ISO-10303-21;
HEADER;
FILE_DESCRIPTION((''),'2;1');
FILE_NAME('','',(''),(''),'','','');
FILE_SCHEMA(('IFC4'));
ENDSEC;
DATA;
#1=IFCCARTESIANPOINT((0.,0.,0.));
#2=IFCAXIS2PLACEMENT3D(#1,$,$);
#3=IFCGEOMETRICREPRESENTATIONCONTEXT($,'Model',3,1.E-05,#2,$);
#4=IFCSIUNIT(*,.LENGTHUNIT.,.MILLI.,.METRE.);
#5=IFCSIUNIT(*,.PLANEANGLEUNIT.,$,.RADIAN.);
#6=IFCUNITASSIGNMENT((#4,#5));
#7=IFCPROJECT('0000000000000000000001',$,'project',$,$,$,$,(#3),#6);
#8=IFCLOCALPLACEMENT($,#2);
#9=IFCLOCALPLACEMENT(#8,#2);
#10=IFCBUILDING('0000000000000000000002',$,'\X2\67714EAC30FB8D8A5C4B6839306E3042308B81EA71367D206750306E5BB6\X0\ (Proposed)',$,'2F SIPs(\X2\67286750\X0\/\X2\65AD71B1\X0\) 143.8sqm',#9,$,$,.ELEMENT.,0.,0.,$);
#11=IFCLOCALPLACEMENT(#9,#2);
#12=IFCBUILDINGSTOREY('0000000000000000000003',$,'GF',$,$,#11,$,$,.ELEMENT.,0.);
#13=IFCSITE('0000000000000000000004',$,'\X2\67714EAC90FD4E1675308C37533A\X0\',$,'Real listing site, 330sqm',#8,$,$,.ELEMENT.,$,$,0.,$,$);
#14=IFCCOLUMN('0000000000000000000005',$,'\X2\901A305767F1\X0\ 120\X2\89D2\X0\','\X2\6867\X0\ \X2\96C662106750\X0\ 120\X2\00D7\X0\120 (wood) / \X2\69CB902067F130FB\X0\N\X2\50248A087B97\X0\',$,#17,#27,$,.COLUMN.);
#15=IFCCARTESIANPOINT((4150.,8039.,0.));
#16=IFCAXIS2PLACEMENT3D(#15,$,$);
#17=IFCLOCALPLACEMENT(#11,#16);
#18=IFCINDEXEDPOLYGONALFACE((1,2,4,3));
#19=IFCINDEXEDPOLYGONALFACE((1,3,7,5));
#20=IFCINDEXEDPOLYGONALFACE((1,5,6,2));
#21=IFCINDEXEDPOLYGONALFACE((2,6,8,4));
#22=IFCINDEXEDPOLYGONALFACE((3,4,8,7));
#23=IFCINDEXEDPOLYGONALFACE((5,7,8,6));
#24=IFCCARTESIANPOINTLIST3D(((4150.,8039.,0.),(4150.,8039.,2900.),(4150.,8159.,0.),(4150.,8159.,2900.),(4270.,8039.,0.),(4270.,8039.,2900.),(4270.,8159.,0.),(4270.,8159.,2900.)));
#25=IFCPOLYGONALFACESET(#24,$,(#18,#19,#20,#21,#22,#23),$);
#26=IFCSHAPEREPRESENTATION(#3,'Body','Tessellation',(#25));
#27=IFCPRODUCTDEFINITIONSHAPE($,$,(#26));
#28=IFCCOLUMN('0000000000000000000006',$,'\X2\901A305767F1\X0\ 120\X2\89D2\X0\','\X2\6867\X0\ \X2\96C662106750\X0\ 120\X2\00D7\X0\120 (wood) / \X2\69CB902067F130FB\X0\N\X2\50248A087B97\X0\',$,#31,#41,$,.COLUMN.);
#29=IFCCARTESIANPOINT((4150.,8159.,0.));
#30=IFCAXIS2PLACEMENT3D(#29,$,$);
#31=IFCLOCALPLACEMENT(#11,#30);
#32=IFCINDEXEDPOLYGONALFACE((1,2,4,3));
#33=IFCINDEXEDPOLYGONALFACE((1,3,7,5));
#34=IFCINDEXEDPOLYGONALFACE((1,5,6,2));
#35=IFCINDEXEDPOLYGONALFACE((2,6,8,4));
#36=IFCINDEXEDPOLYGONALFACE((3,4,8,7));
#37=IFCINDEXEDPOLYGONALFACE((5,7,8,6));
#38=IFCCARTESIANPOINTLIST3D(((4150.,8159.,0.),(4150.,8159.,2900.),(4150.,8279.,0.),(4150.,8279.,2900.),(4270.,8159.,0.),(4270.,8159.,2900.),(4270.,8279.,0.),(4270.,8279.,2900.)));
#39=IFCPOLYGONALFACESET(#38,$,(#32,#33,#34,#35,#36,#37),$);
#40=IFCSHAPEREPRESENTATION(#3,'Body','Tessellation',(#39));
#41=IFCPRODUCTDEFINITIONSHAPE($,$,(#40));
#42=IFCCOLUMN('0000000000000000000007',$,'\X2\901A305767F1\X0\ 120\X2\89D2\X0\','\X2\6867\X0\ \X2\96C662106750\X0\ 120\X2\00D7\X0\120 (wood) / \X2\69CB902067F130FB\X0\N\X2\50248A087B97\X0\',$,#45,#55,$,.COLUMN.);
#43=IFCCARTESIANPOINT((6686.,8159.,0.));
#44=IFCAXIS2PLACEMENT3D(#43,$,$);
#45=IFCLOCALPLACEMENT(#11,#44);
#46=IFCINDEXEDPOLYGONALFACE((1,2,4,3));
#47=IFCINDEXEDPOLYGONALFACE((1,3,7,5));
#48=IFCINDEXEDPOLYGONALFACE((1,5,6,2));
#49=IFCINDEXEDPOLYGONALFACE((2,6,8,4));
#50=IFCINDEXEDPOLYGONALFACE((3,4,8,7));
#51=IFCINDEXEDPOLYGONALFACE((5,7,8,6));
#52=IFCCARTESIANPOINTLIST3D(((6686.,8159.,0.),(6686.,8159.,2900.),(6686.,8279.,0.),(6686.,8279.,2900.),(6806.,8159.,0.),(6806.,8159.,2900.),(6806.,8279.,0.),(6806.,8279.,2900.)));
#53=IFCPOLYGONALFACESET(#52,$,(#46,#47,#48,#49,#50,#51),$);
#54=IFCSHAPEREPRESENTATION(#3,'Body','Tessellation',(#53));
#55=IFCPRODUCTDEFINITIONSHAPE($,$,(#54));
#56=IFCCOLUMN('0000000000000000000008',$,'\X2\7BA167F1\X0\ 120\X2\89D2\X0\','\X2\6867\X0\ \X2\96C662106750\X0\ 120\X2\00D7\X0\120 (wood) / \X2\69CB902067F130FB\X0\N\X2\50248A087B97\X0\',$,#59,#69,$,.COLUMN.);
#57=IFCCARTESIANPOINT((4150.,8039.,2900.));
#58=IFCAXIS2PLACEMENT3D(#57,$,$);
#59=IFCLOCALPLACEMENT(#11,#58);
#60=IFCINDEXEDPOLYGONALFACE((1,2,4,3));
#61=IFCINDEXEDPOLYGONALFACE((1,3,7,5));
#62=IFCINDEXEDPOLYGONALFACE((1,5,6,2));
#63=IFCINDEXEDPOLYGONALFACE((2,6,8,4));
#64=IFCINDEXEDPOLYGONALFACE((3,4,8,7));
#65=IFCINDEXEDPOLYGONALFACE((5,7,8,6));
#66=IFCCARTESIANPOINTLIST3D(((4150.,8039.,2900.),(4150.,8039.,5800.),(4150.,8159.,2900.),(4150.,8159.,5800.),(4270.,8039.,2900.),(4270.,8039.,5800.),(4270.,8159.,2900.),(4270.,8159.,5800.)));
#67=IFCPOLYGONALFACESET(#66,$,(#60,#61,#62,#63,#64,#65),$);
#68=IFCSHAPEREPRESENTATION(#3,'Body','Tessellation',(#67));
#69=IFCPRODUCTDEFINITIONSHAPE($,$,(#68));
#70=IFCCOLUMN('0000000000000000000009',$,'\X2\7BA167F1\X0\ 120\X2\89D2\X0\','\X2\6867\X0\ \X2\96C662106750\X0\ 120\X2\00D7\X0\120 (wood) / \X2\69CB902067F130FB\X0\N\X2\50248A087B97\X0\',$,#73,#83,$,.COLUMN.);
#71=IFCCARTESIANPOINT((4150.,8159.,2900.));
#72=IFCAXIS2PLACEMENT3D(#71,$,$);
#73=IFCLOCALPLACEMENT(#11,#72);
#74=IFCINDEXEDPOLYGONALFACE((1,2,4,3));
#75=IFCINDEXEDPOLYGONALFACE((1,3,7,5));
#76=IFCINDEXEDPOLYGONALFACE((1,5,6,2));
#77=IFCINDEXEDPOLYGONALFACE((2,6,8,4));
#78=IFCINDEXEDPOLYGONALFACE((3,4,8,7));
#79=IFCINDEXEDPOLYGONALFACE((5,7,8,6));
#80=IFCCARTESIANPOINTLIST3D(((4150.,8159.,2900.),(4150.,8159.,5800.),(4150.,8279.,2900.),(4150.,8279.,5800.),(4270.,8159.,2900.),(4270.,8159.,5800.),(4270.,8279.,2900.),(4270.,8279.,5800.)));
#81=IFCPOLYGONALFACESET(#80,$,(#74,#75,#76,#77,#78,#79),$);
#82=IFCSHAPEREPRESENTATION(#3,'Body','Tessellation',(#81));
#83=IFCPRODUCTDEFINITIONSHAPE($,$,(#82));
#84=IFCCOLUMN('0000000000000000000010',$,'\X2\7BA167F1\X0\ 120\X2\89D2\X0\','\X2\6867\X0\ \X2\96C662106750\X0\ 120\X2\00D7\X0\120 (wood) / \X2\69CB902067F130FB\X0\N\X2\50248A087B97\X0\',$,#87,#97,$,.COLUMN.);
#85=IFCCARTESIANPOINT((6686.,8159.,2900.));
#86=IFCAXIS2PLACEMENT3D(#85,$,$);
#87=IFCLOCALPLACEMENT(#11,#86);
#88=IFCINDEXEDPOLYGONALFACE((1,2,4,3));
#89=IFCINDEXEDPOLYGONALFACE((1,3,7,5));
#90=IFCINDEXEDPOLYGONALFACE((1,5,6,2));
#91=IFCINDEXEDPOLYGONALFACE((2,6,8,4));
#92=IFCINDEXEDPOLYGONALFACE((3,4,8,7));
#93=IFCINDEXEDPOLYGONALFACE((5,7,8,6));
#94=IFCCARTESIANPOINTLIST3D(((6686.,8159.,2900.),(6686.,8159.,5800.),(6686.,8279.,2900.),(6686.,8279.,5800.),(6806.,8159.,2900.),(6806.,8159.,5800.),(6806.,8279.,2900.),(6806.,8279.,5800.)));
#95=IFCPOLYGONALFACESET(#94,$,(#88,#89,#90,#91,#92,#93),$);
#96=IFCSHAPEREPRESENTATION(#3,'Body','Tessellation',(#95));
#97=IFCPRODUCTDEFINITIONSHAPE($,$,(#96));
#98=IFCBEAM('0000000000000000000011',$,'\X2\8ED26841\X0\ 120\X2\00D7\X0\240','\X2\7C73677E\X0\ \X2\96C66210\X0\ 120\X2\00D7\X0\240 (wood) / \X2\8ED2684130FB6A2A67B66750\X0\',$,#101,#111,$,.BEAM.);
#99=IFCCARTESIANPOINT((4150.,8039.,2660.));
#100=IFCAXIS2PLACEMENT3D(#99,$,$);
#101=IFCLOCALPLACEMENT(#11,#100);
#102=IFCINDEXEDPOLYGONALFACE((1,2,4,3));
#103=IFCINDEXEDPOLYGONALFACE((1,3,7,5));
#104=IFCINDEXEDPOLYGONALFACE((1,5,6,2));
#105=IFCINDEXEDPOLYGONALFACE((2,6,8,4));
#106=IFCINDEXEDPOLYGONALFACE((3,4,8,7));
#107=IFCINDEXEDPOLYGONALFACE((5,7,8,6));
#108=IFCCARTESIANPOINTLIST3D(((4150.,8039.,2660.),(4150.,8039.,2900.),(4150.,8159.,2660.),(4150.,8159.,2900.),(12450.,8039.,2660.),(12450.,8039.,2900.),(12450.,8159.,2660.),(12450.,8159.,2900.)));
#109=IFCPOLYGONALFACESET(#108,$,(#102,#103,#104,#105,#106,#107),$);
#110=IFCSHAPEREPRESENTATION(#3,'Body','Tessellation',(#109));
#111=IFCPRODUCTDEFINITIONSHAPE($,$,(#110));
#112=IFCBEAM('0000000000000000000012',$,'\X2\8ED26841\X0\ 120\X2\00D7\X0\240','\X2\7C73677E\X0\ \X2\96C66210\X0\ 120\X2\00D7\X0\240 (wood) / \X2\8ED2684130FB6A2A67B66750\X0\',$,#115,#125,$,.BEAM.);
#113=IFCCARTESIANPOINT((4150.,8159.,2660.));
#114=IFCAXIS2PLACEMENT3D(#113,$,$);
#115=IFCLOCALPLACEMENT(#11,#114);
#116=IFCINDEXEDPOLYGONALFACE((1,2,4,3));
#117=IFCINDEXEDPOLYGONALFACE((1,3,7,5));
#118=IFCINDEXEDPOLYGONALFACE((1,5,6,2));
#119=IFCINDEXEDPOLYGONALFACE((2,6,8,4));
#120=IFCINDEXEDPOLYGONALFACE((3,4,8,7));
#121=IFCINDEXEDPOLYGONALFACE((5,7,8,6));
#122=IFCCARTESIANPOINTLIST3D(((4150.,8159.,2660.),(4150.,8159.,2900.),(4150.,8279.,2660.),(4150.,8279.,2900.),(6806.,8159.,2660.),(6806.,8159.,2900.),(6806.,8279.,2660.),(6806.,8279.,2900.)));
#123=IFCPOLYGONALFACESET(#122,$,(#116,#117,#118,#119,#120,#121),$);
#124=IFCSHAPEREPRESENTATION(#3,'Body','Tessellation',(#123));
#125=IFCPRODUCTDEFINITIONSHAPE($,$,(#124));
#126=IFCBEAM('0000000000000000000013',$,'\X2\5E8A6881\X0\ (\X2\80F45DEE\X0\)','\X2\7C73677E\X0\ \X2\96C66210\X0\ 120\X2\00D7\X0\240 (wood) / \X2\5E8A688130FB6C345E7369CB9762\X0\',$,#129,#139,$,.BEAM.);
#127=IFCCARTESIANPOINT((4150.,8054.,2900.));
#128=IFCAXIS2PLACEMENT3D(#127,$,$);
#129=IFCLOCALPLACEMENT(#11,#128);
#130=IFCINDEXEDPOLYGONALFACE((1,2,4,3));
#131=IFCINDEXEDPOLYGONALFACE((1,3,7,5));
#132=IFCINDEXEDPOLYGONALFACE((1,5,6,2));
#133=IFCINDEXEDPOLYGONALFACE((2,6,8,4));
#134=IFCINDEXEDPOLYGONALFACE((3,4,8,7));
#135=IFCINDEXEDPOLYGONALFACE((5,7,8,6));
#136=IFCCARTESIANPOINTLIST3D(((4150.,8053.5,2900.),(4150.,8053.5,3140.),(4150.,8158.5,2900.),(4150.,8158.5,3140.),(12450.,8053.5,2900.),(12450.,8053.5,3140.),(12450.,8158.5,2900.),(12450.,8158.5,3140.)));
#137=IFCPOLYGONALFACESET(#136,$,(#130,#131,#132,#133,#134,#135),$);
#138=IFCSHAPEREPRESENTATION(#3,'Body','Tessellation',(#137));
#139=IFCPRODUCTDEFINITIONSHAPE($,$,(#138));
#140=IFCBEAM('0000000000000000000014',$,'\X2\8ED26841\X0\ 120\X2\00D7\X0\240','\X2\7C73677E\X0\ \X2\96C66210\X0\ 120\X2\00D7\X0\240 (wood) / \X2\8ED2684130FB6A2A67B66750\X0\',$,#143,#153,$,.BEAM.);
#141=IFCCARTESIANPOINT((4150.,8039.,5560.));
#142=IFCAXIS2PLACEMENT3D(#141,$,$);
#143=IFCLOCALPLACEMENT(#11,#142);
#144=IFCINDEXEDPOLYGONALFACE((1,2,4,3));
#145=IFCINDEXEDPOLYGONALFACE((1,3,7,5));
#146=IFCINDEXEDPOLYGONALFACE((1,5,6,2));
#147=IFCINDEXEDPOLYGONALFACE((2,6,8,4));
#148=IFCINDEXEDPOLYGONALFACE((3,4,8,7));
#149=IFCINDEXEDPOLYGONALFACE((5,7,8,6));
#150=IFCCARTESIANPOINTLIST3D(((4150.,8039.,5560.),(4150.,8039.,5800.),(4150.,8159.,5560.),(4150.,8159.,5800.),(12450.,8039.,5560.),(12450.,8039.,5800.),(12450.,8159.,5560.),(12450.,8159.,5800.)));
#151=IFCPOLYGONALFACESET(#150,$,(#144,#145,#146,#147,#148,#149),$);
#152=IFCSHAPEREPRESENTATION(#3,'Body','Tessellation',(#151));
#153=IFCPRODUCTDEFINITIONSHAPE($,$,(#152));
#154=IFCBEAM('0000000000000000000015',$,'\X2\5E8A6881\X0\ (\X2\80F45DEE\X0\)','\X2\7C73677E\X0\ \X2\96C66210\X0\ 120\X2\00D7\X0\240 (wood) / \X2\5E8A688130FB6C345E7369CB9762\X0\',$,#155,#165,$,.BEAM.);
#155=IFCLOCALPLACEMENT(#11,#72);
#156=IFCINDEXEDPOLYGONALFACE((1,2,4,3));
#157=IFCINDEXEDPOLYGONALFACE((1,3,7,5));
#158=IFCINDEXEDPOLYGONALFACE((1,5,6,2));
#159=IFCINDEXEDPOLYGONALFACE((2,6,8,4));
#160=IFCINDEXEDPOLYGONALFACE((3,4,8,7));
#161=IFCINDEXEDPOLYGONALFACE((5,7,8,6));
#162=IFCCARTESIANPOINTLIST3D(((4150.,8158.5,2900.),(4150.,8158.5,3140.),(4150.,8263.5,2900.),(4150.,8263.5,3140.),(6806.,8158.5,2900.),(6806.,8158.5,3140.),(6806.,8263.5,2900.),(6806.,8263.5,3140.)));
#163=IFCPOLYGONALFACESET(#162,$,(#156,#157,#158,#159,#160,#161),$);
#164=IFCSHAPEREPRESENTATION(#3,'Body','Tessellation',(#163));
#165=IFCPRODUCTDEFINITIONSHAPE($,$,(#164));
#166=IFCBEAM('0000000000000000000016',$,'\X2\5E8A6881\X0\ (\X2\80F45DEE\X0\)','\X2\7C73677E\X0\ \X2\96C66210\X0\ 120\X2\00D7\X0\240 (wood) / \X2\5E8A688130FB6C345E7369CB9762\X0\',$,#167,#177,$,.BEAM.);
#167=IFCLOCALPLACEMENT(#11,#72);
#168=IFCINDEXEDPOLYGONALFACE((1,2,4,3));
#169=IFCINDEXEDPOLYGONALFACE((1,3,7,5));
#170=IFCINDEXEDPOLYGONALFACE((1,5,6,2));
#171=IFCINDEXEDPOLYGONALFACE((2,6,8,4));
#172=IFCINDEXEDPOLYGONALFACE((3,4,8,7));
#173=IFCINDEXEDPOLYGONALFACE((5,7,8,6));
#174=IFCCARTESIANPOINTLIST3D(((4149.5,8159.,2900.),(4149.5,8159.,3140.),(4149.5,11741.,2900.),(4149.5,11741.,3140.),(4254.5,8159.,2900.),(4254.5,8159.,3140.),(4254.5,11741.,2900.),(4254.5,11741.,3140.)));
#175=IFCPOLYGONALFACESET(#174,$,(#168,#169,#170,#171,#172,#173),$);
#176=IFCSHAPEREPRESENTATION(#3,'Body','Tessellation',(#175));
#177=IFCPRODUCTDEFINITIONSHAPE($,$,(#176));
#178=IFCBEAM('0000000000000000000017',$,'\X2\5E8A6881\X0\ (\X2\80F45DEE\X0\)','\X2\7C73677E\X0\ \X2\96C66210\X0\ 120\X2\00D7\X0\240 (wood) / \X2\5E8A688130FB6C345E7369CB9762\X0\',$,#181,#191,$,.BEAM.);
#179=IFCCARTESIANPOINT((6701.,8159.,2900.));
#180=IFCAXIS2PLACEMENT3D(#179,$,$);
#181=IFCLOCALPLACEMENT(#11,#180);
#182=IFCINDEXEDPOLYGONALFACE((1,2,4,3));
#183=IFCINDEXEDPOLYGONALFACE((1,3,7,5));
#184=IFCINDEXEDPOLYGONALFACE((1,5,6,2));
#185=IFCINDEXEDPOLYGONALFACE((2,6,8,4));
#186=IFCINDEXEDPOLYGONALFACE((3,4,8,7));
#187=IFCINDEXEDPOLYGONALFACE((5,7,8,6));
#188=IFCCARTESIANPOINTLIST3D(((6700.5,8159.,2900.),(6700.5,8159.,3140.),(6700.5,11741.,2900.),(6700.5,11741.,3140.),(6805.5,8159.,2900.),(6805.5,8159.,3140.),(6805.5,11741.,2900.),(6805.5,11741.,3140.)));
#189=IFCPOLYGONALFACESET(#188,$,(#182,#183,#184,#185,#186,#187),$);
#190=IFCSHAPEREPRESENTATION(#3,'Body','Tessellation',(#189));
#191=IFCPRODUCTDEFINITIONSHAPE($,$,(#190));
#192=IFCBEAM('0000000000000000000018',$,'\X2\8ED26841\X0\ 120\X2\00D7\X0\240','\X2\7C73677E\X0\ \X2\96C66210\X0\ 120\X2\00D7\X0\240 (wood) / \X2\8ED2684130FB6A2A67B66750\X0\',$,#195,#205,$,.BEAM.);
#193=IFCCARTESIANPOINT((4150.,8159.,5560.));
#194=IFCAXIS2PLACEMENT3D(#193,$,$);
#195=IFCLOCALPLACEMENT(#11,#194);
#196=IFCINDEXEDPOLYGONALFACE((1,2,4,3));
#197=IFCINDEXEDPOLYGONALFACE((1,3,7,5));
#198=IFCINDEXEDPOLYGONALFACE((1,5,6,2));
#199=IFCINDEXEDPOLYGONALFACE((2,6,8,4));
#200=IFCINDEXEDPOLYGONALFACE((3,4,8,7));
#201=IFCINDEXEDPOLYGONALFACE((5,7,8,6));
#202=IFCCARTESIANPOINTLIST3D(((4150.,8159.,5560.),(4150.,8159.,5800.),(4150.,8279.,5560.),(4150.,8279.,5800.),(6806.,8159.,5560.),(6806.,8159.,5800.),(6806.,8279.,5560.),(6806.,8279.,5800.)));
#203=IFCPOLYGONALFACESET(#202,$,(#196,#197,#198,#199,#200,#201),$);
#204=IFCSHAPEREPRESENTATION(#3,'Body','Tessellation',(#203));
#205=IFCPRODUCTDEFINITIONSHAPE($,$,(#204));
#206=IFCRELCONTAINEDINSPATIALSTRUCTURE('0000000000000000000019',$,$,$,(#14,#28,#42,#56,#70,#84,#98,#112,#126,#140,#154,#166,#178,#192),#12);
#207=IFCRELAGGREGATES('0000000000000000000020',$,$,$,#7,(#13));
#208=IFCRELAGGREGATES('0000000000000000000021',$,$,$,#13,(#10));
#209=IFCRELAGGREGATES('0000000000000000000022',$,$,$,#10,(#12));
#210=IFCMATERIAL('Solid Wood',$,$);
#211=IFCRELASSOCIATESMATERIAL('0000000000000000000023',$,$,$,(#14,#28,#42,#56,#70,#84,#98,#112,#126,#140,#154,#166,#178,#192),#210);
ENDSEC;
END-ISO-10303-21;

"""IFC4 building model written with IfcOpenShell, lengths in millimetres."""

from ifc_helpers import new_model, si_unit, frame, frame_2d, origin, place, context, project, spatial, rectangle, extrude, material, element, save


model = new_model("IFC4")

# Units and contexts
model_context = context("Model", 3, precision=1e-05, world=origin())
ifc_project = project(units=[si_unit("LENGTHUNIT", "METRE", prefix="MILLI"), si_unit("PLANEANGLEUNIT", "RADIAN")], contexts=[model_context])

# Site, building, storey
site_placement = place(None, origin())
site = spatial("IfcSite", under=ifc_project, at=site_placement, Name="東京都世田谷区", ObjectType="Real listing site, 330sqm", CompositionType="ELEMENT", RefElevation=0.0)
building_placement = place(site_placement, origin())
building = spatial("IfcBuilding", under=site, at=building_placement, Name="東京・越屋根のある自然素材の家 (Proposed)", ObjectType="2F SIPs(木材/断熱) 143.8sqm", CompositionType="ELEMENT", ElevationOfRefHeight=0.0, ElevationOfTerrain=0.0)
storey_placement = place(building_placement, origin())
storey = spatial("IfcBuildingStorey", under=building, at=storey_placement, Name="GF", CompositionType="ELEMENT", Elevation=0.0)

# Columns
ifc_material_1 = material(Name="Solid Wood")
column_1_placement = place(storey_placement, frame((4150.0, 8039.0, 0.0)))
element("IfcColumn", 1, at=column_1_placement, inside=storey, material=ifc_material_1, Name="通し柱 120角", Description="桧 集成材 120×120 (wood) / 構造柱・N値計算", PredefinedType="COLUMN", context=model_context, shape_type="SweptSolid", body=[
    extrude(rectangle(XDim=120.0, YDim=120.0, at=frame_2d((60.0, 60.0))), frame((4150.0, 8039.0, 0.0)), (0.0, 0.0, 1.0), 2900.0),
])
column_2_placement = place(storey_placement, frame((4150.0, 8159.0, 0.0)))
element("IfcColumn", 2, at=column_2_placement, inside=storey, material=ifc_material_1, Name="通し柱 120角", Description="桧 集成材 120×120 (wood) / 構造柱・N値計算", PredefinedType="COLUMN", context=model_context, shape_type="SweptSolid", body=[
    extrude(rectangle(XDim=120.0, YDim=120.0, at=frame_2d((60.0, 60.0))), frame((4150.0, 8159.0, 0.0)), (0.0, 0.0, 1.0), 2900.0),
])
column_3_placement = place(storey_placement, frame((6686.0, 8159.0, 0.0)))
element("IfcColumn", 3, at=column_3_placement, inside=storey, material=ifc_material_1, Name="通し柱 120角", Description="桧 集成材 120×120 (wood) / 構造柱・N値計算", PredefinedType="COLUMN", context=model_context, shape_type="SweptSolid", body=[
    extrude(rectangle(XDim=120.0, YDim=120.0, at=frame_2d((60.0, 60.0))), frame((6686.0, 8159.0, 0.0)), (0.0, 0.0, 1.0), 2900.0),
])
column_4_placement = place(storey_placement, frame((4150.0, 8039.0, 2900.0)))
element("IfcColumn", 4, at=column_4_placement, inside=storey, material=ifc_material_1, Name="管柱 120角", Description="桧 集成材 120×120 (wood) / 構造柱・N値計算", PredefinedType="COLUMN", context=model_context, shape_type="SweptSolid", body=[
    extrude(rectangle(XDim=120.0, YDim=120.0, at=frame_2d((60.0, 60.0))), frame((4150.0, 8039.0, 2900.0)), (0.0, 0.0, 1.0), 2900.0),
])
column_5_placement = place(storey_placement, frame((4150.0, 8159.0, 2900.0)))
element("IfcColumn", 5, at=column_5_placement, inside=storey, material=ifc_material_1, Name="管柱 120角", Description="桧 集成材 120×120 (wood) / 構造柱・N値計算", PredefinedType="COLUMN", context=model_context, shape_type="SweptSolid", body=[
    extrude(rectangle(XDim=120.0, YDim=120.0, at=frame_2d((60.0, 60.0))), frame((4150.0, 8159.0, 2900.0)), (0.0, 0.0, 1.0), 2900.0),
])
column_6_placement = place(storey_placement, frame((6686.0, 8159.0, 2900.0)))
element("IfcColumn", 6, at=column_6_placement, inside=storey, material=ifc_material_1, Name="管柱 120角", Description="桧 集成材 120×120 (wood) / 構造柱・N値計算", PredefinedType="COLUMN", context=model_context, shape_type="SweptSolid", body=[
    extrude(rectangle(XDim=120.0, YDim=120.0, at=frame_2d((60.0, 60.0))), frame((6686.0, 8159.0, 2900.0)), (0.0, 0.0, 1.0), 2900.0),
])

# Beams
beam_1_placement = place(storey_placement, frame((4150.0, 8039.0, 2660.0)))
element("IfcBeam", 7, at=beam_1_placement, inside=storey, material=ifc_material_1, Name="軒桁 120×240", Description="米松 集成 120×240 (wood) / 軒桁・横架材", PredefinedType="BEAM", context=model_context, shape_type="SweptSolid", body=[
    extrude(rectangle(XDim=8300.0, YDim=120.0, at=frame_2d((4150.0, 60.0))), frame((4150.0, 8039.0, 2660.0)), (0.0, 0.0, 1.0), 240.0),
])
beam_2_placement = place(storey_placement, frame((4150.0, 8159.0, 2660.0)))
element("IfcBeam", 8, at=beam_2_placement, inside=storey, material=ifc_material_1, Name="軒桁 120×240", Description="米松 集成 120×240 (wood) / 軒桁・横架材", PredefinedType="BEAM", context=model_context, shape_type="SweptSolid", body=[
    extrude(rectangle(XDim=2656.0, YDim=120.0, at=frame_2d((1328.0, 60.0))), frame((4150.0, 8159.0, 2660.0)), (0.0, 0.0, 1.0), 240.0),
])
beam_3_placement = place(storey_placement, frame((4150.0, 8054.0, 2900.0)))
element("IfcBeam", 9, at=beam_3_placement, inside=storey, material=ifc_material_1, Name="床梁 (胴差)", Description="米松 集成 120×240 (wood) / 床梁・水平構面", PredefinedType="BEAM", context=model_context, shape_type="SweptSolid", body=[
    extrude(rectangle(XDim=8300.0, YDim=105.0, at=frame_2d((4150.0, 52.0))), frame((4150.0, 8054.0, 2900.0)), (0.0, 0.0, 1.0), 240.0),
])
beam_4_placement = place(storey_placement, frame((4150.0, 8039.0, 5560.0)))
element("IfcBeam", 10, at=beam_4_placement, inside=storey, material=ifc_material_1, Name="軒桁 120×240", Description="米松 集成 120×240 (wood) / 軒桁・横架材", PredefinedType="BEAM", context=model_context, shape_type="SweptSolid", body=[
    extrude(rectangle(XDim=8300.0, YDim=120.0, at=frame_2d((4150.0, 60.0))), frame((4150.0, 8039.0, 5560.0)), (0.0, 0.0, 1.0), 240.0),
])
beam_5_placement = place(storey_placement, frame((4150.0, 8159.0, 2900.0)))
element("IfcBeam", 11, at=beam_5_placement, inside=storey, material=ifc_material_1, Name="床梁 (胴差)", Description="米松 集成 120×240 (wood) / 床梁・水平構面", PredefinedType="BEAM", context=model_context, shape_type="SweptSolid", body=[
    extrude(rectangle(XDim=2656.0, YDim=105.0, at=frame_2d((1328.0, 52.0))), frame((4150.0, 8159.0, 2900.0)), (0.0, 0.0, 1.0), 240.0),
])
beam_6_placement = place(storey_placement, frame((4150.0, 8159.0, 2900.0)))
element("IfcBeam", 12, at=beam_6_placement, inside=storey, material=ifc_material_1, Name="床梁 (胴差)", Description="米松 集成 120×240 (wood) / 床梁・水平構面", PredefinedType="BEAM", context=model_context, shape_type="SweptSolid", body=[
    extrude(rectangle(XDim=105.0, YDim=3582.0, at=frame_2d((52.0, 1791.0))), frame((4150.0, 8159.0, 2900.0)), (0.0, 0.0, 1.0), 240.0),
])
beam_7_placement = place(storey_placement, frame((6701.0, 8159.0, 2900.0)))
element("IfcBeam", 13, at=beam_7_placement, inside=storey, material=ifc_material_1, Name="床梁 (胴差)", Description="米松 集成 120×240 (wood) / 床梁・水平構面", PredefinedType="BEAM", context=model_context, shape_type="SweptSolid", body=[
    extrude(rectangle(XDim=105.0, YDim=3582.0, at=frame_2d((52.0, 1791.0))), frame((6701.0, 8159.0, 2900.0)), (0.0, 0.0, 1.0), 240.0),
])
beam_8_placement = place(storey_placement, frame((4150.0, 8159.0, 5560.0)))
element("IfcBeam", 14, at=beam_8_placement, inside=storey, material=ifc_material_1, Name="軒桁 120×240", Description="米松 集成 120×240 (wood) / 軒桁・横架材", PredefinedType="BEAM", context=model_context, shape_type="SweptSolid", body=[
    extrude(rectangle(XDim=2656.0, YDim=120.0, at=frame_2d((1328.0, 60.0))), frame((4150.0, 8159.0, 5560.0)), (0.0, 0.0, 1.0), 240.0),
])

save(model, "model.ifc")
